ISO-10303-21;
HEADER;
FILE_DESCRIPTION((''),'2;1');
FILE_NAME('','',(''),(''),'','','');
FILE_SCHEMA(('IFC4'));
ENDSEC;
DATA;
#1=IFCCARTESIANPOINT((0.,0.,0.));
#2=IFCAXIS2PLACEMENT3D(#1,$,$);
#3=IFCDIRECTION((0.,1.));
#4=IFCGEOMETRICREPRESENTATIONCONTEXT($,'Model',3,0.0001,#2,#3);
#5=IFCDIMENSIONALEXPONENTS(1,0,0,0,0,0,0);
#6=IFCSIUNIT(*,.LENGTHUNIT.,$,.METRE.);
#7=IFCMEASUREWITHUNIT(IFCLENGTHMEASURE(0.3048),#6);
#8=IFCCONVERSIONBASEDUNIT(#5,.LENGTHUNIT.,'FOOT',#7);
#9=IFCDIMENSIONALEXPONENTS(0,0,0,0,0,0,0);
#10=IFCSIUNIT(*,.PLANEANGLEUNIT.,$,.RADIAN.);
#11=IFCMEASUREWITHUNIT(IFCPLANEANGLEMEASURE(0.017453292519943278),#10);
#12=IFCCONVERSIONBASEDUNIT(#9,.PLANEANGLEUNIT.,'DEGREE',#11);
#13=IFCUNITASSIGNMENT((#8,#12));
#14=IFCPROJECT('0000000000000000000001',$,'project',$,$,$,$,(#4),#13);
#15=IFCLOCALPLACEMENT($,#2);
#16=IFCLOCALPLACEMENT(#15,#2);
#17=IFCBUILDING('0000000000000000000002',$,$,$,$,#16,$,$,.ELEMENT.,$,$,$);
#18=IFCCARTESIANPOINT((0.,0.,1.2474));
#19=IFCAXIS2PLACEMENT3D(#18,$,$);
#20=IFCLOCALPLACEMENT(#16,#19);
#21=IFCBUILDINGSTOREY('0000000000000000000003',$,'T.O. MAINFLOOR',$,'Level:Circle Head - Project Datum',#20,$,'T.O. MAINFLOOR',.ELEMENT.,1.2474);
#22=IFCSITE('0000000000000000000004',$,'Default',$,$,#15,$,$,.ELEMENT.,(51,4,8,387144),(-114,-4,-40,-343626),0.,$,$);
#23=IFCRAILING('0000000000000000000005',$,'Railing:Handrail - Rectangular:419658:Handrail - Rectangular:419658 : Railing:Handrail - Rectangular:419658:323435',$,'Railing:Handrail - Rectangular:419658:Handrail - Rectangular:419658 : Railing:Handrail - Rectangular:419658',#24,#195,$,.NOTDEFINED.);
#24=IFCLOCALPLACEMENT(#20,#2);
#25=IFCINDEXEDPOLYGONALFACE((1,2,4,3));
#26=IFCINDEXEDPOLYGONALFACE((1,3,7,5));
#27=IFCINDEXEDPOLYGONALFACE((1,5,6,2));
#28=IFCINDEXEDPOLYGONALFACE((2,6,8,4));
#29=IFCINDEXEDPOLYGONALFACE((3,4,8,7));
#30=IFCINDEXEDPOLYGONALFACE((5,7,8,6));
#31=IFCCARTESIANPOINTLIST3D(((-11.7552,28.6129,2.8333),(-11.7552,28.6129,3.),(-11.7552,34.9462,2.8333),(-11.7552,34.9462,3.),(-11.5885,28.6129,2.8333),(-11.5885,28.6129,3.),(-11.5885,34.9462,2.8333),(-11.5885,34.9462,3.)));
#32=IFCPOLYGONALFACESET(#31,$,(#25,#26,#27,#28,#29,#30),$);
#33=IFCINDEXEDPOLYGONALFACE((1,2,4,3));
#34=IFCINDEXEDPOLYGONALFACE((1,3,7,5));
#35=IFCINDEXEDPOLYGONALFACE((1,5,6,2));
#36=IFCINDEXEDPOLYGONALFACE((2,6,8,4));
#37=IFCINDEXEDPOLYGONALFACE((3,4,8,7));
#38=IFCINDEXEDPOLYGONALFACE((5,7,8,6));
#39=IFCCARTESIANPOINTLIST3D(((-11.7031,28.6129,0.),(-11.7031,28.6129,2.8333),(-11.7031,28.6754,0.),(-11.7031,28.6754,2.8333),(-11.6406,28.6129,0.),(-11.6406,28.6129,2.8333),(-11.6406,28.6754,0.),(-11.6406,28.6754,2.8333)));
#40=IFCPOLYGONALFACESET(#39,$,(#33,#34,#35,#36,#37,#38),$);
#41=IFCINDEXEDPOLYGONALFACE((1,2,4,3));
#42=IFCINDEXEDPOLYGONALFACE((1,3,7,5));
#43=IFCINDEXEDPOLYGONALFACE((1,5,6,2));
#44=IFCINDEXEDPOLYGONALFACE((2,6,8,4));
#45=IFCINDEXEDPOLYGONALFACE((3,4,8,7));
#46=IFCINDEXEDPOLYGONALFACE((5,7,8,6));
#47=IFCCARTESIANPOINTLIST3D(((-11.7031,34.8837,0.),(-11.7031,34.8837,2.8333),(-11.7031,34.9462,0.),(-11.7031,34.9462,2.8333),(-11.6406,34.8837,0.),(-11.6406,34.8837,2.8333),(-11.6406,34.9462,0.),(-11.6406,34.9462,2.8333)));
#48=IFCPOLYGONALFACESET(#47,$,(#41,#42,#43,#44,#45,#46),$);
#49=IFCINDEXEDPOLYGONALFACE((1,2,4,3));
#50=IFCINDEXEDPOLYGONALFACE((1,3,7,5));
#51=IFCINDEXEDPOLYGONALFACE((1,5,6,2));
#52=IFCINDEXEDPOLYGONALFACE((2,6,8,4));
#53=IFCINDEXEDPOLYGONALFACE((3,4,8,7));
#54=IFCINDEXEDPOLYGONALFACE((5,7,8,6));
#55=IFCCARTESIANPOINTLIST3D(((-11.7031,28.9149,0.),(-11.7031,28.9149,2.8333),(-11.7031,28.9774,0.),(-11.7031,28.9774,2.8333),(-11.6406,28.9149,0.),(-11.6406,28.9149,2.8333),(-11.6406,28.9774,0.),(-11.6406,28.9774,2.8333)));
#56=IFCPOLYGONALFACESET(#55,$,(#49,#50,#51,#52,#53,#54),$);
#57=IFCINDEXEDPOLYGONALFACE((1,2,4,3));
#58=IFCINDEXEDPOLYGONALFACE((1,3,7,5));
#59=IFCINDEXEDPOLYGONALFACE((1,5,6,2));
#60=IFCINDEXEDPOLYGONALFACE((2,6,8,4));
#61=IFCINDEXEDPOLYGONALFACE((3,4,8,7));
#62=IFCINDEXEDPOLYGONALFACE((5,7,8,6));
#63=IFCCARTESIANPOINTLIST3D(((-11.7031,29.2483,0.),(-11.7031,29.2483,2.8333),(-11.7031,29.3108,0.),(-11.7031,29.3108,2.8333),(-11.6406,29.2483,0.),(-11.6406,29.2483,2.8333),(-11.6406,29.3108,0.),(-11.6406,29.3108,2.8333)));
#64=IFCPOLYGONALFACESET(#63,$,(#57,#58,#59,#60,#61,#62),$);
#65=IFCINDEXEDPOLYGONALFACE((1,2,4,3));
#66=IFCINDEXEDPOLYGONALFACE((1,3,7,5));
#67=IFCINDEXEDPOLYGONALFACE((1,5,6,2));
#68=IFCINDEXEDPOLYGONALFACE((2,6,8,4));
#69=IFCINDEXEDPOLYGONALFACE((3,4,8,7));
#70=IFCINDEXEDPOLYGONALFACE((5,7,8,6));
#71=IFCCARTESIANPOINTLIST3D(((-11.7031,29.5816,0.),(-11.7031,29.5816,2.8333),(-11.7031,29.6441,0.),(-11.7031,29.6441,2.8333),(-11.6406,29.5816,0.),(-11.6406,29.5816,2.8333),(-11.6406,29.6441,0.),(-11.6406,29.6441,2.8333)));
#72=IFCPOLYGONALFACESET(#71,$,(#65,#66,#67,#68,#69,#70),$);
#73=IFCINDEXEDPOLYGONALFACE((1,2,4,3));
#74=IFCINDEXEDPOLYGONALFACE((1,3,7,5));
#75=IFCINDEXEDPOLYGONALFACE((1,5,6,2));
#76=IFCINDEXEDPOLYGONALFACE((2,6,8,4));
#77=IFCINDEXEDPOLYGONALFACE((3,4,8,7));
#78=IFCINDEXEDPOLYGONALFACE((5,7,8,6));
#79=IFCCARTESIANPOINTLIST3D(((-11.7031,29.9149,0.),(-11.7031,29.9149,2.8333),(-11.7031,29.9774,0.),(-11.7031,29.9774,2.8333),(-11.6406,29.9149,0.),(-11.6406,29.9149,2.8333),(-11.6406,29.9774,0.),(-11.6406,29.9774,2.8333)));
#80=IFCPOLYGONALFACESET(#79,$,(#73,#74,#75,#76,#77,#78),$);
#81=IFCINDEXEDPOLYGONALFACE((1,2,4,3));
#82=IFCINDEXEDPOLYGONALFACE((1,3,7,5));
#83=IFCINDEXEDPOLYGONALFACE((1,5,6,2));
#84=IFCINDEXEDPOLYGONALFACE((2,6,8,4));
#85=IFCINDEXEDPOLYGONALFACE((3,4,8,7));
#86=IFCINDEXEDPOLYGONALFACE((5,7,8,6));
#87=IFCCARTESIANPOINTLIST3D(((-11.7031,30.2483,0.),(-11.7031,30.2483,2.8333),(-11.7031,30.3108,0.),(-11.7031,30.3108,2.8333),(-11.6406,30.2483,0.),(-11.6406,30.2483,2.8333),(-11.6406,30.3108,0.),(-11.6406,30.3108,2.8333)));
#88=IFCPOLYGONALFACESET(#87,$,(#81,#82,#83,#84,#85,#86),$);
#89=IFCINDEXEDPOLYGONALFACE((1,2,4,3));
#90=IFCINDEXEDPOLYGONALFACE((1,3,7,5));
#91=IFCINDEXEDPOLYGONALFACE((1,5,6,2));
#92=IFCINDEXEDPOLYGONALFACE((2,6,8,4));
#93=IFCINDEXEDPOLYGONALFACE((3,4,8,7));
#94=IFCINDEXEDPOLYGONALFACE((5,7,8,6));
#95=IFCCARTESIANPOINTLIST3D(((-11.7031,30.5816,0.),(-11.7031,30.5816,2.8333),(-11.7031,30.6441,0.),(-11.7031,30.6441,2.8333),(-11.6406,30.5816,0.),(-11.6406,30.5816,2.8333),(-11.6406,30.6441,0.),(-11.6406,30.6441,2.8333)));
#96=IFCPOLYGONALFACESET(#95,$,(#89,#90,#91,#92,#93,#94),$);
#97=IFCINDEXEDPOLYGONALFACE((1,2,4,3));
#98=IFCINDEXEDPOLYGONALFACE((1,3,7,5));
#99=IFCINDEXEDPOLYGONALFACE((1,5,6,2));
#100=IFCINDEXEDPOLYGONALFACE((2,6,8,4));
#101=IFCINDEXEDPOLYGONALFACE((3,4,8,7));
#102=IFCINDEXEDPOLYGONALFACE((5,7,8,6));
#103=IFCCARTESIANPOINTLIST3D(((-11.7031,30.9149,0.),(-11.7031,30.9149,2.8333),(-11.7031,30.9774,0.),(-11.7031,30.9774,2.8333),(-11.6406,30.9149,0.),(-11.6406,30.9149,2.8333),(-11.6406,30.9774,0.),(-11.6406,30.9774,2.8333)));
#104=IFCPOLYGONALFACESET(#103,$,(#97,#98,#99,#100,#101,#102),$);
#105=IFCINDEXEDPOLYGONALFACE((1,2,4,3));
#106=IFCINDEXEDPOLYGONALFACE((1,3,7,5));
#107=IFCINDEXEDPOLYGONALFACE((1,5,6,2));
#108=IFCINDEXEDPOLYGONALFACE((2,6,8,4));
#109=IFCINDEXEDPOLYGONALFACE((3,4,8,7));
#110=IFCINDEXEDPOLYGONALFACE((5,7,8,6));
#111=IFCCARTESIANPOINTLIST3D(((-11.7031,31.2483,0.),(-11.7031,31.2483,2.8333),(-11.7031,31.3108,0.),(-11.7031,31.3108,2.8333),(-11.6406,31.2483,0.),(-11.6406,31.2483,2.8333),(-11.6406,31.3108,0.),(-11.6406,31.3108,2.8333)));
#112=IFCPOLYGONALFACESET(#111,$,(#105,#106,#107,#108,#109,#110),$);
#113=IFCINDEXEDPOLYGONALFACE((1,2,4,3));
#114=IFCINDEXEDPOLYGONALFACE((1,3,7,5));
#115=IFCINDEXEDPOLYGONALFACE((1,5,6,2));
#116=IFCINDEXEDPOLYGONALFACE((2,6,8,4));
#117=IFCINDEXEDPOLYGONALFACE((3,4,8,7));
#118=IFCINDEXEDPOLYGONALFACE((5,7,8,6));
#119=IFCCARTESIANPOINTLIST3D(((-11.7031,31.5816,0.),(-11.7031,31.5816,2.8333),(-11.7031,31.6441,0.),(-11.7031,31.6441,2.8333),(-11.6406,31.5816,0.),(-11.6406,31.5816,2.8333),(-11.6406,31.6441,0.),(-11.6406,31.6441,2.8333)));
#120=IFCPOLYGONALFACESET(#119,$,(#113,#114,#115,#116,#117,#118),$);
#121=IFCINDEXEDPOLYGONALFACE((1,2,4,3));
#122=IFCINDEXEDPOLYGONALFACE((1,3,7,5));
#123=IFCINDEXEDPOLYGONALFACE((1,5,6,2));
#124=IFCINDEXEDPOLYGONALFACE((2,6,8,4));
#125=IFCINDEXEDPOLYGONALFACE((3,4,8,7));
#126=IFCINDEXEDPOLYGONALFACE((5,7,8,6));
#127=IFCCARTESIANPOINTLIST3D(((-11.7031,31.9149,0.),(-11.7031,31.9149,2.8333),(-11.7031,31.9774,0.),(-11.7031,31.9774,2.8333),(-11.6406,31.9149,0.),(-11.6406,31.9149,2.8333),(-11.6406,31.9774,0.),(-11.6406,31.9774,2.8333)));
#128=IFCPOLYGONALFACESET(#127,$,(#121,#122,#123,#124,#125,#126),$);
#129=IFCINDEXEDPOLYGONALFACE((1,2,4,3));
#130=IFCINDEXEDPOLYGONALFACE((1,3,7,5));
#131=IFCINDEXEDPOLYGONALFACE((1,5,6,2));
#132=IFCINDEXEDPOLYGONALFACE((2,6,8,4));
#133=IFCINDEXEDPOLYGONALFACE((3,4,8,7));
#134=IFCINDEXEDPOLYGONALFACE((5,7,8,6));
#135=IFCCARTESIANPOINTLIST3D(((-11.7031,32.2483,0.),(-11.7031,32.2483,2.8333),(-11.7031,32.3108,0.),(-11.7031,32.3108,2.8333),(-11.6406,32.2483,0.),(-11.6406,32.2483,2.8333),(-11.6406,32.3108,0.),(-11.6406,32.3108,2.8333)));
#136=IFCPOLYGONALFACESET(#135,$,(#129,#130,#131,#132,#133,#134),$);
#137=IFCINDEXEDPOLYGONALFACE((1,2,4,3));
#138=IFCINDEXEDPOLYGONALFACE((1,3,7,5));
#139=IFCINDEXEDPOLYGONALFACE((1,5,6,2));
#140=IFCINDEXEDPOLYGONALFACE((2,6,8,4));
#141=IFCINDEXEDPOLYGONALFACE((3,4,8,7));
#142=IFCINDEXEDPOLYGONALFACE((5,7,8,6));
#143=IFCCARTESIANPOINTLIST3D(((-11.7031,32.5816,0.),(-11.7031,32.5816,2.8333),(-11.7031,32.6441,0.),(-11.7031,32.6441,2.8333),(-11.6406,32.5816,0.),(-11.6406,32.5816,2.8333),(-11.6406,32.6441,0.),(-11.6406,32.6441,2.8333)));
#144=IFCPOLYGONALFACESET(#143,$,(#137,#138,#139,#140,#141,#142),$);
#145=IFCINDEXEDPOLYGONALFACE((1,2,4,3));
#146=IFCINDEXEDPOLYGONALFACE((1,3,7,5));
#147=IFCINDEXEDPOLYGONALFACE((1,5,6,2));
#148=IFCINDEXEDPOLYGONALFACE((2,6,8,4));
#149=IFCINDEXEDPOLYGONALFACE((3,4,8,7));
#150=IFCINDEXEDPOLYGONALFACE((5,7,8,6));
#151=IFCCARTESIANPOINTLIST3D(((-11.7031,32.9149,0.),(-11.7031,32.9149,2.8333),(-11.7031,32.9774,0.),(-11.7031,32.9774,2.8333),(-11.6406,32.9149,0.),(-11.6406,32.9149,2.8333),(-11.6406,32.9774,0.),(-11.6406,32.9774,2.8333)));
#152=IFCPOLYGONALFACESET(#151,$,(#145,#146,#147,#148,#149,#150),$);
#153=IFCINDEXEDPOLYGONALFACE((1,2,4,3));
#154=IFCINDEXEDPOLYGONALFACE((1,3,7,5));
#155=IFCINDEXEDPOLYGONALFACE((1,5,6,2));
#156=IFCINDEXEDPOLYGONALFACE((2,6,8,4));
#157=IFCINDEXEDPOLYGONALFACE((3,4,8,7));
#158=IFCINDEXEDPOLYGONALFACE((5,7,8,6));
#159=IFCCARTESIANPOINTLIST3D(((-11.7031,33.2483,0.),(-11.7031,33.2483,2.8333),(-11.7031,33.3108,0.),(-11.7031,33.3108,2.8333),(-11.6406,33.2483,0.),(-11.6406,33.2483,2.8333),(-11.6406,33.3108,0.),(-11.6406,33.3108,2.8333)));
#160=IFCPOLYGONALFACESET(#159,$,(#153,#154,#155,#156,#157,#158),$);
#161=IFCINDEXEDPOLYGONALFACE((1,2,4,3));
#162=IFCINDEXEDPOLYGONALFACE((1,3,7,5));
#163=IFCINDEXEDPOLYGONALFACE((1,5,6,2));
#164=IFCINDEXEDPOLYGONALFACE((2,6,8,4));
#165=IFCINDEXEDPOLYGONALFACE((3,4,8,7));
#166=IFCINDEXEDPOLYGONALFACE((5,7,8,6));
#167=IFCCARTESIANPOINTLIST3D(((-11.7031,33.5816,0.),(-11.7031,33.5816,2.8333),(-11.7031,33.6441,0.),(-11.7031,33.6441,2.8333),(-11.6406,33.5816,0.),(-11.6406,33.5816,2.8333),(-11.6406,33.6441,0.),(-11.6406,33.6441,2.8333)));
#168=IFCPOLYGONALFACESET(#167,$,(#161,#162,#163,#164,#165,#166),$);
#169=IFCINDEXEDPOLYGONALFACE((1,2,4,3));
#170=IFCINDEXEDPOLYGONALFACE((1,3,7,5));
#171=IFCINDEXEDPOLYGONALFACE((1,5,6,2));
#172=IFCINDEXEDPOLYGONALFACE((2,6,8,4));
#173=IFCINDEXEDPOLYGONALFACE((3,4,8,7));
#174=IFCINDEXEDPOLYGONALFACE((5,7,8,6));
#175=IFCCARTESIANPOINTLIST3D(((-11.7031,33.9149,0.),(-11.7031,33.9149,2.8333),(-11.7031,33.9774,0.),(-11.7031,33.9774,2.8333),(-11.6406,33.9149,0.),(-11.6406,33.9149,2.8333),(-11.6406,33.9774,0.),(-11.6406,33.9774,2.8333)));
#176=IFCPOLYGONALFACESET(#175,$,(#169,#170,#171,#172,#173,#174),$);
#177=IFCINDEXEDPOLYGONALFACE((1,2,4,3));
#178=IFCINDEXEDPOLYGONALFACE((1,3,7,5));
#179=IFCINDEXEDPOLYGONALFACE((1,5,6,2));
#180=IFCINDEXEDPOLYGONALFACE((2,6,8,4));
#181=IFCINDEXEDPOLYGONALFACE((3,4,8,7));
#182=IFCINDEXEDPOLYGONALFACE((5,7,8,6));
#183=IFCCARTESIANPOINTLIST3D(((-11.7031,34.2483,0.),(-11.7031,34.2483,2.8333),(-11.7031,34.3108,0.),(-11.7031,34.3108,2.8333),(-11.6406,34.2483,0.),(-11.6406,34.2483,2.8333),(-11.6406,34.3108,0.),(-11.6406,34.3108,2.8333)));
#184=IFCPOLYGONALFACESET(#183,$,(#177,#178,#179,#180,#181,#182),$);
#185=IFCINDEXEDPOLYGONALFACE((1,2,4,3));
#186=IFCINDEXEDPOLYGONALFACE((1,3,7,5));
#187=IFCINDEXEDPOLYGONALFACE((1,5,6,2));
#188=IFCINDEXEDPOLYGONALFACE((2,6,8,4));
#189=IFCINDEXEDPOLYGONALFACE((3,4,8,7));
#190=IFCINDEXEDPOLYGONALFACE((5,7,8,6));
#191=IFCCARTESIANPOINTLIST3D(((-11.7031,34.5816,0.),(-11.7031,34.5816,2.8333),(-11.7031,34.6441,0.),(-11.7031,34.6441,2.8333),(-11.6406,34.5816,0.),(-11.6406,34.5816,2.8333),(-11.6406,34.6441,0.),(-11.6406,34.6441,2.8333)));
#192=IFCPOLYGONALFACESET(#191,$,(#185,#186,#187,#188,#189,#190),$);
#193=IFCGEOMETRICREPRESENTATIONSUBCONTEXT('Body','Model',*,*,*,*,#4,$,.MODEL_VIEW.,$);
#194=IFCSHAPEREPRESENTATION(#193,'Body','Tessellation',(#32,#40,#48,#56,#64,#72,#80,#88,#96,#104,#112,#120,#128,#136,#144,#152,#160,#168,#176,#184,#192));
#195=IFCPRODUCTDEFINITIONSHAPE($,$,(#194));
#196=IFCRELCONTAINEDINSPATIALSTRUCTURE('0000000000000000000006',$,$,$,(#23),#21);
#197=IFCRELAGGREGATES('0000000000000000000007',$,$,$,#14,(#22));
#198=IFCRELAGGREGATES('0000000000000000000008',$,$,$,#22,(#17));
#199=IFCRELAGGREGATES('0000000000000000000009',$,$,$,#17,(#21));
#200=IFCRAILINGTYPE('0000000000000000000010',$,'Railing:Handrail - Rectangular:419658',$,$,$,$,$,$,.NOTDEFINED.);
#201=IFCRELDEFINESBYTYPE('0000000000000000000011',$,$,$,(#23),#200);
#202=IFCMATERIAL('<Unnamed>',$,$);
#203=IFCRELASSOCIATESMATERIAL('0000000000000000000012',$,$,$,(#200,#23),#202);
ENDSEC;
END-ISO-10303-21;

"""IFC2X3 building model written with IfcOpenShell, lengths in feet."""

from ifc_helpers import new_model, entity, si_unit, converted_unit, direction, frame, frame_2d, origin, origin_2d_with_axis, place, context, subcontext, project, spatial, rectangle, extrude, source, transform, mapped, material, type_object, type_shapes, element, save


model = new_model("IFC2X3")

# Units and contexts
model_context = context("Model", 3, precision=0.0001, world=origin(), true_north=direction((0.0, 1.0)))
body_context = subcontext(model_context, "Body", "Model", "MODEL_VIEW")
ifc_project = project(units=[converted_unit("LENGTHUNIT", "FOOT", entity("IfcLengthMeasure", 0.3048), si_unit("LENGTHUNIT", "METRE"), dimensions=[1, 0, 0, 0, 0, 0, 0]), converted_unit("PLANEANGLEUNIT", "DEGREE", entity("IfcPlaneAngleMeasure", 0.017453292519943278), si_unit("PLANEANGLEUNIT", "RADIAN"), dimensions=[0, 0, 0, 0, 0, 0, 0])], contexts=[model_context])

# Site, building, storey
site_placement = place(None, origin())
site = spatial("IfcSite", under=ifc_project, at=site_placement, Name="Default", CompositionType="ELEMENT", RefLatitude=(51, 4, 8, 387144), RefLongitude=(-114, -4, -40, -343626), RefElevation=0.0)
building_placement = place(site_placement, origin())
building = spatial("IfcBuilding", under=site, at=building_placement, CompositionType="ELEMENT")
storey_placement = place(building_placement, frame((0.0, 0.0, 1.2474)))
storey = spatial("IfcBuildingStorey", under=building, at=storey_placement, Name="T.O. MAINFLOOR", ObjectType="Level:Circle Head - Project Datum", LongName="T.O. MAINFLOOR", CompositionType="ELEMENT", Elevation=1.2474)

# Railing
ifc_material_1 = material(Name="<Unnamed>")
railing_type = type_object("IfcRailingType", Name="Railing:Handrail - Rectangular:419658", PredefinedType="NOTDEFINED", material=ifc_material_1)
shared_shape_1 = source(origin(), body_context, "Body", "SweptSolid", [
    extrude(rectangle(XDim=0.1667, YDim=6.3333, at=frame_2d((0.0, 0.0), x_axis=(1.0, 0.0))), frame((-11.6719, 31.7795, 4.0807), z_axis=(0.0, 0.0, 1.0), x_axis=(-1.0, 0.0, 0.0)), (0.0, 0.0, 1.0), 0.1667),
    extrude(rectangle(XDim=0.0625, YDim=0.0625, at=origin_2d_with_axis()), frame((-11.6719, 28.6441, 1.2474), z_axis=(0.0, 0.0, 1.0), x_axis=(-1.0, 0.0, 0.0)), (0.0, 0.0, 1.0), 2.8333),
    extrude(rectangle(XDim=0.0625, YDim=0.0625, at=origin_2d_with_axis()), frame((-11.6719, 34.9149, 1.2474), z_axis=(0.0, 0.0, 1.0), x_axis=(-1.0, 0.0, 0.0)), (0.0, 0.0, 1.0), 2.8333),
    extrude(rectangle(XDim=0.0625, YDim=0.0625, at=origin_2d_with_axis()), frame((-11.6719, 28.9462, 1.2474), z_axis=(0.0, 0.0, 1.0), x_axis=(-1.0, 0.0, 0.0)), (0.0, 0.0, 1.0), 2.8333),
    extrude(rectangle(XDim=0.0625, YDim=0.0625, at=origin_2d_with_axis()), frame((-11.6719, 29.2795, 1.2474), z_axis=(0.0, 0.0, 1.0), x_axis=(-1.0, 0.0, 0.0)), (0.0, 0.0, 1.0), 2.8333),
    extrude(rectangle(XDim=0.0625, YDim=0.0625, at=origin_2d_with_axis()), frame((-11.6719, 29.6129, 1.2474), z_axis=(0.0, 0.0, 1.0), x_axis=(-1.0, 0.0, 0.0)), (0.0, 0.0, 1.0), 2.8333),
    extrude(rectangle(XDim=0.0625, YDim=0.0625, at=origin_2d_with_axis()), frame((-11.6719, 29.9462, 1.2474), z_axis=(0.0, 0.0, 1.0), x_axis=(-1.0, 0.0, 0.0)), (0.0, 0.0, 1.0), 2.8333),
    extrude(rectangle(XDim=0.0625, YDim=0.0625, at=origin_2d_with_axis()), frame((-11.6719, 30.2795, 1.2474), z_axis=(0.0, 0.0, 1.0), x_axis=(-1.0, 0.0, 0.0)), (0.0, 0.0, 1.0), 2.8333),
    extrude(rectangle(XDim=0.0625, YDim=0.0625, at=origin_2d_with_axis()), frame((-11.6719, 30.6129, 1.2474), z_axis=(0.0, 0.0, 1.0), x_axis=(-1.0, 0.0, 0.0)), (0.0, 0.0, 1.0), 2.8333),
    extrude(rectangle(XDim=0.0625, YDim=0.0625, at=origin_2d_with_axis()), frame((-11.6719, 30.9462, 1.2474), z_axis=(0.0, 0.0, 1.0), x_axis=(-1.0, 0.0, 0.0)), (0.0, 0.0, 1.0), 2.8333),
    extrude(rectangle(XDim=0.0625, YDim=0.0625, at=origin_2d_with_axis()), frame((-11.6719, 31.2795, 1.2474), z_axis=(0.0, 0.0, 1.0), x_axis=(-1.0, 0.0, 0.0)), (0.0, 0.0, 1.0), 2.8333),
    extrude(rectangle(XDim=0.0625, YDim=0.0625, at=origin_2d_with_axis()), frame((-11.6719, 31.6129, 1.2474), z_axis=(0.0, 0.0, 1.0), x_axis=(-1.0, 0.0, 0.0)), (0.0, 0.0, 1.0), 2.8333),
    extrude(rectangle(XDim=0.0625, YDim=0.0625, at=origin_2d_with_axis()), frame((-11.6719, 31.9462, 1.2474), z_axis=(0.0, 0.0, 1.0), x_axis=(-1.0, 0.0, 0.0)), (0.0, 0.0, 1.0), 2.8333),
    extrude(rectangle(XDim=0.0625, YDim=0.0625, at=origin_2d_with_axis()), frame((-11.6719, 32.2795, 1.2474), z_axis=(0.0, 0.0, 1.0), x_axis=(-1.0, 0.0, 0.0)), (0.0, 0.0, 1.0), 2.8333),
    extrude(rectangle(XDim=0.0625, YDim=0.0625, at=origin_2d_with_axis()), frame((-11.6719, 32.6129, 1.2474), z_axis=(0.0, 0.0, 1.0), x_axis=(-1.0, 0.0, 0.0)), (0.0, 0.0, 1.0), 2.8333),
    extrude(rectangle(XDim=0.0625, YDim=0.0625, at=origin_2d_with_axis()), frame((-11.6719, 32.9462, 1.2474), z_axis=(0.0, 0.0, 1.0), x_axis=(-1.0, 0.0, 0.0)), (0.0, 0.0, 1.0), 2.8333),
    extrude(rectangle(XDim=0.0625, YDim=0.0625, at=origin_2d_with_axis()), frame((-11.6719, 33.2795, 1.2474), z_axis=(0.0, 0.0, 1.0), x_axis=(-1.0, 0.0, 0.0)), (0.0, 0.0, 1.0), 2.8333),
    extrude(rectangle(XDim=0.0625, YDim=0.0625, at=origin_2d_with_axis()), frame((-11.6719, 33.6129, 1.2474), z_axis=(0.0, 0.0, 1.0), x_axis=(-1.0, 0.0, 0.0)), (0.0, 0.0, 1.0), 2.8333),
    extrude(rectangle(XDim=0.0625, YDim=0.0625, at=origin_2d_with_axis()), frame((-11.6719, 33.9462, 1.2474), z_axis=(0.0, 0.0, 1.0), x_axis=(-1.0, 0.0, 0.0)), (0.0, 0.0, 1.0), 2.8333),
    extrude(rectangle(XDim=0.0625, YDim=0.0625, at=origin_2d_with_axis()), frame((-11.6719, 34.2795, 1.2474), z_axis=(0.0, 0.0, 1.0), x_axis=(-1.0, 0.0, 0.0)), (0.0, 0.0, 1.0), 2.8333),
    extrude(rectangle(XDim=0.0625, YDim=0.0625, at=origin_2d_with_axis()), frame((-11.6719, 34.6129, 1.2474), z_axis=(0.0, 0.0, 1.0), x_axis=(-1.0, 0.0, 0.0)), (0.0, 0.0, 1.0), 2.8333),
])
type_shapes(railing_type, [shared_shape_1])
railing_placement = place(storey_placement, frame((0.0, 0.0, -1.2474)))
element("IfcRailing", 1, at=railing_placement, inside=storey, type_object=railing_type, material=ifc_material_1, Name="Railing:Handrail - Rectangular:419658:Handrail - Rectangular:419658 : Railing:Handrail - Rectangular:419658:323435", ObjectType="Railing:Handrail - Rectangular:419658:Handrail - Rectangular:419658 : Railing:Handrail - Rectangular:419658", PredefinedType="NOTDEFINED", context=body_context, shape_type="MappedRepresentation", body=[
    mapped(shared_shape_1, transform((0.0, 0.0, 0.0), scale=1.0)),
])

save(model, "model.ifc")
